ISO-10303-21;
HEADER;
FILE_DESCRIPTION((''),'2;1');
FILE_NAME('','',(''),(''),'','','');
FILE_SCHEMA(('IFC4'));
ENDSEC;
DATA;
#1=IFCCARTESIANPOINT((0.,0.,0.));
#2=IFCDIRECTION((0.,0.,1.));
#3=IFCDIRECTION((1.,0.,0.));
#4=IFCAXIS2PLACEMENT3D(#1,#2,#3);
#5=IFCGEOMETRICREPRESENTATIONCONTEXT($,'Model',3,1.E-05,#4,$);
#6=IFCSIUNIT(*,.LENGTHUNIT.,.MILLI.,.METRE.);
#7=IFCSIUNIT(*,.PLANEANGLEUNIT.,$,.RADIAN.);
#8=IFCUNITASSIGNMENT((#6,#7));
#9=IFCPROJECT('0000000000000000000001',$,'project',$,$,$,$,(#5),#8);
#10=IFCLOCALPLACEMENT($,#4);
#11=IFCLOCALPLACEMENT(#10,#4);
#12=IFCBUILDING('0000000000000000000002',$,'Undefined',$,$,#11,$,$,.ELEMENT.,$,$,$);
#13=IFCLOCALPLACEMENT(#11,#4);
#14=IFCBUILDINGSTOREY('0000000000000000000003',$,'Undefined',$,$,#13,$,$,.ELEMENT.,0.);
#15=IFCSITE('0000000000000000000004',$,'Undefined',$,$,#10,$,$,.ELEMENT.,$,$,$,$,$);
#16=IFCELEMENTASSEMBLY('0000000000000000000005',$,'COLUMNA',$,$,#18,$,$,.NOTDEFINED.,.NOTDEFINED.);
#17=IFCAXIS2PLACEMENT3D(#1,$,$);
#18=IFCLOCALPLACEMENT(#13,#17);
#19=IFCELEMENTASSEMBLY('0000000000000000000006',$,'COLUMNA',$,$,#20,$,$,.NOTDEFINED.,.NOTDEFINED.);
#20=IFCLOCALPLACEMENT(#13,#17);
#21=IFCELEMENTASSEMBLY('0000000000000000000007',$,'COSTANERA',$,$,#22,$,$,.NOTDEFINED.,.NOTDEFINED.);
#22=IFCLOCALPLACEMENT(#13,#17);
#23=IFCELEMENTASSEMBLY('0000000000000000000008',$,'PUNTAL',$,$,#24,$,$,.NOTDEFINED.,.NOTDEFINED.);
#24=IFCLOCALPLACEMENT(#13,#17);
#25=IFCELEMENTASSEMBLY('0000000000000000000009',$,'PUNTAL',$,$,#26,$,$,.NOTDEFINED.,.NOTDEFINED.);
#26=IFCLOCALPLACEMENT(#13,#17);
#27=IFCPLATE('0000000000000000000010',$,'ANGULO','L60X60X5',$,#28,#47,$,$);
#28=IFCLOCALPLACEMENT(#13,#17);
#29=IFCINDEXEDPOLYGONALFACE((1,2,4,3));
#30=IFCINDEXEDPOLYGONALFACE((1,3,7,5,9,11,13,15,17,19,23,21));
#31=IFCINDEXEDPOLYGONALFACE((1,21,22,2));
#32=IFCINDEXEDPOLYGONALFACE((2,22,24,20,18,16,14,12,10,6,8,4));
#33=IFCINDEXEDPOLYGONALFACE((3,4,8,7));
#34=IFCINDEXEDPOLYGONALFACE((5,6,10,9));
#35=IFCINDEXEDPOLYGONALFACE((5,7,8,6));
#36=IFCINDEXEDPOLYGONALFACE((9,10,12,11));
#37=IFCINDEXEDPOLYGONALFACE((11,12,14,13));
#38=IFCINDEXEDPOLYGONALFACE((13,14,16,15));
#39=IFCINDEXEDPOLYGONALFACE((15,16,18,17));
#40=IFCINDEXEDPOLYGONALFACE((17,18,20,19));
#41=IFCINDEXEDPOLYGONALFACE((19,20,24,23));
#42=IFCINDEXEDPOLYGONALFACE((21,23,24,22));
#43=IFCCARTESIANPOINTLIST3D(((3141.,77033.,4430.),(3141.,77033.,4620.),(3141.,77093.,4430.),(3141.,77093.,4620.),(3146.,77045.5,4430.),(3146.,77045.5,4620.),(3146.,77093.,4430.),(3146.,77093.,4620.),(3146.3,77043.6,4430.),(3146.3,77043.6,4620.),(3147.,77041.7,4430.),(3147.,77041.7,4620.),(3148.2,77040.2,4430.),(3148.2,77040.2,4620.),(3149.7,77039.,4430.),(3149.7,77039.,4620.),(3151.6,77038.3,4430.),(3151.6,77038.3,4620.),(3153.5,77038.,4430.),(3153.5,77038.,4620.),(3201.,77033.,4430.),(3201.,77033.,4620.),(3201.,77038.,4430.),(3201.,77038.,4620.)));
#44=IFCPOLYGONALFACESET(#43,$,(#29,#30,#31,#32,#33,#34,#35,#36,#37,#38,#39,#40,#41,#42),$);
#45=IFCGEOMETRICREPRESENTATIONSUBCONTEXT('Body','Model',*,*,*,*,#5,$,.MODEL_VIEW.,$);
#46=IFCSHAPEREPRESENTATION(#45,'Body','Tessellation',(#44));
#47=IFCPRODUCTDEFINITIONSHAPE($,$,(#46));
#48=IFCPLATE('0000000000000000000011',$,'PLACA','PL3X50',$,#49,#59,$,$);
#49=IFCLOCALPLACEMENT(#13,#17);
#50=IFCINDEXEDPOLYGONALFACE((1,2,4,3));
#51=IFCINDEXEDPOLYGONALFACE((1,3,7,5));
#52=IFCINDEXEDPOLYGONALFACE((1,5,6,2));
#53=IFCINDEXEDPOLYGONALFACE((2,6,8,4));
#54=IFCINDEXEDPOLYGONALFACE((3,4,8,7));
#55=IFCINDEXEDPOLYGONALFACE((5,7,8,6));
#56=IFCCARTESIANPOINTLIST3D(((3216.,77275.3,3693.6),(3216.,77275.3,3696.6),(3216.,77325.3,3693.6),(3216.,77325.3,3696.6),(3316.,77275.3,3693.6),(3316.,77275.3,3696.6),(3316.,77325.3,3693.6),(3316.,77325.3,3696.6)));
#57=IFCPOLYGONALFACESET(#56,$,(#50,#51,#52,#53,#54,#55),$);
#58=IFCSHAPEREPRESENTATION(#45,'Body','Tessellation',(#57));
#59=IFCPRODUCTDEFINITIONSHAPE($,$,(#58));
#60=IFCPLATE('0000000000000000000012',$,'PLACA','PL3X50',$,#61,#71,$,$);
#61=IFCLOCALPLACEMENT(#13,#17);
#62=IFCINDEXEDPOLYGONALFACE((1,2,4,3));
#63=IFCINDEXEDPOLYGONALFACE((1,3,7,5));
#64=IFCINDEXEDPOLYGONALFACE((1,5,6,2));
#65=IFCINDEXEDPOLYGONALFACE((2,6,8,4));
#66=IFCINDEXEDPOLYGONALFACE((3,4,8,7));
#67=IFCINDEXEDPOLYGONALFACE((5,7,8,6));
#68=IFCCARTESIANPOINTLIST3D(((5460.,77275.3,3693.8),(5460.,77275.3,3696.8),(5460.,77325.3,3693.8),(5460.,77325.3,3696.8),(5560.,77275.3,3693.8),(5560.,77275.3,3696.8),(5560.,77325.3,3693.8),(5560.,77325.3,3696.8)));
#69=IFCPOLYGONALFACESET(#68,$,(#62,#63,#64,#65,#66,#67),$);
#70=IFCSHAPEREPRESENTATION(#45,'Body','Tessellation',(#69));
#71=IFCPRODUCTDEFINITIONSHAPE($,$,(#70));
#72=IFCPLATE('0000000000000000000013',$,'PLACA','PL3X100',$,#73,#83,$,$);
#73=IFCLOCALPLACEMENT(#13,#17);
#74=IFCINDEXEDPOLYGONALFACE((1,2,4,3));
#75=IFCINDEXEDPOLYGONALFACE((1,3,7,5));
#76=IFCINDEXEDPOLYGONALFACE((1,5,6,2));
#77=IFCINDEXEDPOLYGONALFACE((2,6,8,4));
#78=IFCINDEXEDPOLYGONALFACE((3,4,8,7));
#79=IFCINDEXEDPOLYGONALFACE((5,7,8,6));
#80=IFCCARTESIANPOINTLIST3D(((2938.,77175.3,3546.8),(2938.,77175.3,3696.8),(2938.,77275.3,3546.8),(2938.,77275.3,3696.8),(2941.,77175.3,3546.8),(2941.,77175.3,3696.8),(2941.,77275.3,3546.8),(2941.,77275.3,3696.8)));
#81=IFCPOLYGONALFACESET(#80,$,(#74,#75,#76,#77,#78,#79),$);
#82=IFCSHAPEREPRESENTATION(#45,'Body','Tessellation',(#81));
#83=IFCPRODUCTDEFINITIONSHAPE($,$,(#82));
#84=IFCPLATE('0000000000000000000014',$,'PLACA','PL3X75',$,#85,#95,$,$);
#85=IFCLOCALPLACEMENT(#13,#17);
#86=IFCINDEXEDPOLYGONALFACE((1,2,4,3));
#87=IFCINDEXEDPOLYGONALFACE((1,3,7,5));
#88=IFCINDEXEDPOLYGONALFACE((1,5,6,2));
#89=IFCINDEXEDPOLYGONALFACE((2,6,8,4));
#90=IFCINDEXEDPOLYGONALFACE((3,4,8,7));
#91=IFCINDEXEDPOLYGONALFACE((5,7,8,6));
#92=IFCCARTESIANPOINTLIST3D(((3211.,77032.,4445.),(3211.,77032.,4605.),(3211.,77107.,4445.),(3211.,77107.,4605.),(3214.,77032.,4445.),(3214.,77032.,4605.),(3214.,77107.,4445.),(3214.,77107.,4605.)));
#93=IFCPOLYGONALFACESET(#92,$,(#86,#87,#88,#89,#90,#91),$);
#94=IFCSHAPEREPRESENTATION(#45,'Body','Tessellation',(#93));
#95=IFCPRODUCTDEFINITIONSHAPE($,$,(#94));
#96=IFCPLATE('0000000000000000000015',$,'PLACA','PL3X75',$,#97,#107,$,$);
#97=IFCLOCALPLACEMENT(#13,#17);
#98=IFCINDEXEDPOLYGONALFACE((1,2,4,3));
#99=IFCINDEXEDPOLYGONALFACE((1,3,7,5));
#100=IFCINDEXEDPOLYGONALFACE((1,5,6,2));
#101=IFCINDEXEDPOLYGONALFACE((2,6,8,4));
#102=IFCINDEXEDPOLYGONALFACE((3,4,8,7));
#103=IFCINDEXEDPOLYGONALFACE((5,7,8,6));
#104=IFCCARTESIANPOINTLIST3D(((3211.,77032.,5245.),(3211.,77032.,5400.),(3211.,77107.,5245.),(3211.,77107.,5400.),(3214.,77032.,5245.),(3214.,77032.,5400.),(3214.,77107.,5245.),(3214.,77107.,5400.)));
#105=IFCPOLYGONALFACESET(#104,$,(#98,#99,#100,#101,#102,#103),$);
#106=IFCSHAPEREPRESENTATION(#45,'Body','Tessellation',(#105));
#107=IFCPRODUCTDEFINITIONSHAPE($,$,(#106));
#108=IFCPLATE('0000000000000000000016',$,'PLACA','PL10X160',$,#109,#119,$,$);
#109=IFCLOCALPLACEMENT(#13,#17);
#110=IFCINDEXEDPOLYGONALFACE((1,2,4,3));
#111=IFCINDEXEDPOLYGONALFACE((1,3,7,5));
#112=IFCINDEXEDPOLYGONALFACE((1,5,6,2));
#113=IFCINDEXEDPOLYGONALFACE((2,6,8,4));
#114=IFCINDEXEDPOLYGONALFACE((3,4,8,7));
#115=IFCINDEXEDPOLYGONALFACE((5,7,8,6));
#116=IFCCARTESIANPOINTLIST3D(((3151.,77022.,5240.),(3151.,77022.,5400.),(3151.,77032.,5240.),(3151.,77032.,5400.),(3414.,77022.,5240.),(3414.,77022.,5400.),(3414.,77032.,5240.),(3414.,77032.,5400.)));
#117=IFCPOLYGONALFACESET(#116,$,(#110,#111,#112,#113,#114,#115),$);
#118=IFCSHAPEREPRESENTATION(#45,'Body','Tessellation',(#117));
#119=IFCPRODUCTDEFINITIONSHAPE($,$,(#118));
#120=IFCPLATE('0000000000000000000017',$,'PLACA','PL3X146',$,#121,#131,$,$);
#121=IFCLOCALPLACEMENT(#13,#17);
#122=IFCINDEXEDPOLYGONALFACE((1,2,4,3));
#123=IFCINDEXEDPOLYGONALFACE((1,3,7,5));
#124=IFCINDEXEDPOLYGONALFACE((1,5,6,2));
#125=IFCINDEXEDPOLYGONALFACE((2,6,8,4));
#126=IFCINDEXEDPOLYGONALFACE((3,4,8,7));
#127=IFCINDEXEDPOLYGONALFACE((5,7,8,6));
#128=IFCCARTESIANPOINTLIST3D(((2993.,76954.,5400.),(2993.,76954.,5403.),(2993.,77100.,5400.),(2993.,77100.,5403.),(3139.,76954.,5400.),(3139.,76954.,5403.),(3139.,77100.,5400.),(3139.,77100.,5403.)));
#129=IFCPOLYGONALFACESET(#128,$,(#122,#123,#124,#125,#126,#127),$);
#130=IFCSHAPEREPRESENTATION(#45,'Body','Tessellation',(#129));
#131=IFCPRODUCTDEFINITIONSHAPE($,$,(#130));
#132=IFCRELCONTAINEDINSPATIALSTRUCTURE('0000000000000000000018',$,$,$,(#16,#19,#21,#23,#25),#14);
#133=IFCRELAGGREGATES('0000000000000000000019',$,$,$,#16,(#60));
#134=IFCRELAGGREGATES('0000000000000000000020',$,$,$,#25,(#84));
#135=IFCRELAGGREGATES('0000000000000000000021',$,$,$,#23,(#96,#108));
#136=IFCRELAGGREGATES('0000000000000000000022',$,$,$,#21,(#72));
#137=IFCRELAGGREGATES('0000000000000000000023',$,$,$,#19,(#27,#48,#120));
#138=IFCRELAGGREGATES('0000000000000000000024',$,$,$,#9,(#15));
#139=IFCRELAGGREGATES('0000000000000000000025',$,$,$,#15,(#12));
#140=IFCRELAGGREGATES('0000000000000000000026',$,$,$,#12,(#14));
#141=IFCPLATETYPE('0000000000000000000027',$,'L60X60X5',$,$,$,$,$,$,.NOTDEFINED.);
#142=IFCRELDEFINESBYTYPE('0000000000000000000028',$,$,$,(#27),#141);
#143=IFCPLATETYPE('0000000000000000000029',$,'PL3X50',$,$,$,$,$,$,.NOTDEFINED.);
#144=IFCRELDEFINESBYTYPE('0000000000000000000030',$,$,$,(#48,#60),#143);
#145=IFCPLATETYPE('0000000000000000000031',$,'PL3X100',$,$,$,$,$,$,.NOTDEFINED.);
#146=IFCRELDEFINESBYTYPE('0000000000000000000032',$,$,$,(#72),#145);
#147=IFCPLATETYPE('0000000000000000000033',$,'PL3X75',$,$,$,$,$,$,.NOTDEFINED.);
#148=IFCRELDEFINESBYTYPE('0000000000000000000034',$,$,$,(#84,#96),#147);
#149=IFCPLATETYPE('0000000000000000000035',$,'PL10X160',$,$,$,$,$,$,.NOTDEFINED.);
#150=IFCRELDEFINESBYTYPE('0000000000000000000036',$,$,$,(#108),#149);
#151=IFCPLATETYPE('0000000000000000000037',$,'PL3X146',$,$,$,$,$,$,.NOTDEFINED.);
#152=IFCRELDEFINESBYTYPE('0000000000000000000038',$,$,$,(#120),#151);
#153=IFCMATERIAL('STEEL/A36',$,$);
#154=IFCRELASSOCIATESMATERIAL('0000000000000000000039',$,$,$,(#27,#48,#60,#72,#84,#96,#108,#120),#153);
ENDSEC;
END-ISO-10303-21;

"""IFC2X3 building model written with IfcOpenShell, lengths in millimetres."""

from ifc_helpers import new_model, si_unit, frame, origin_with_axes, origin_2d_with_axis, place, context, subcontext, project, spatial, polyline, l_section, outline, extrude, material, type_object, element, aggregate, save


model = new_model("IFC2X3")

# Units and contexts
model_context = context("Model", 3, precision=1e-05, world=origin_with_axes())
body_context = subcontext(model_context, "Body", "Model", "MODEL_VIEW")
ifc_project = project(units=[si_unit("LENGTHUNIT", "METRE", prefix="MILLI"), si_unit("PLANEANGLEUNIT", "RADIAN")], contexts=[model_context])

# Site, building, storey
site_placement = place(None, origin_with_axes())
site = spatial("IfcSite", under=ifc_project, at=site_placement, Name="Undefined", CompositionType="ELEMENT")
building_placement = place(site_placement, origin_with_axes())
building = spatial("IfcBuilding", under=site, at=building_placement, Name="Undefined", CompositionType="ELEMENT")
storey_placement = place(building_placement, origin_with_axes())
storey = spatial("IfcBuildingStorey", under=building, at=storey_placement, Name="Undefined", CompositionType="ELEMENT", Elevation=0.0)

# Element assemblies
assembly_1_placement = place(storey_placement, origin_with_axes())
assembly_1 = element("IfcElementAssembly", 1, at=assembly_1_placement, inside=storey, Name="COLUMNA", AssemblyPlace="NOTDEFINED", PredefinedType="NOTDEFINED")
ifc_material_1 = material(Name="STEEL/A36")
assembly_2_placement = place(storey_placement, origin_with_axes())
assembly_2 = element("IfcElementAssembly", 2, at=assembly_2_placement, inside=storey, Name="COLUMNA", AssemblyPlace="NOTDEFINED", PredefinedType="NOTDEFINED")
assembly_3_placement = place(storey_placement, origin_with_axes())
assembly_3 = element("IfcElementAssembly", 3, at=assembly_3_placement, inside=storey, Name="COSTANERA", AssemblyPlace="NOTDEFINED", PredefinedType="NOTDEFINED")
assembly_4_placement = place(storey_placement, origin_with_axes())
assembly_4 = element("IfcElementAssembly", 4, at=assembly_4_placement, inside=storey, Name="PUNTAL", AssemblyPlace="NOTDEFINED", PredefinedType="NOTDEFINED")
assembly_5_placement = place(storey_placement, origin_with_axes())
assembly_5 = element("IfcElementAssembly", 5, at=assembly_5_placement, inside=storey, Name="PUNTAL", AssemblyPlace="NOTDEFINED", PredefinedType="NOTDEFINED")

# Plates
plate_type_1 = type_object("IfcPlateType", Name="L60X60X5", PredefinedType="NOTDEFINED")
plate_1_placement = place(assembly_2_placement, frame((3171.0, 77063.0, 4620.0), z_axis=(0.0, 1.0, 0.0), x_axis=(0.0, 0.0, -1.0)))
plate_1 = element("IfcPlate", 6, at=plate_1_placement, type_object=plate_type_1, material=ifc_material_1, Name="ANGULO", Description="L60X60X5", context=body_context, shape_type="SweptSolid", body=[
    extrude(l_section(Depth=60.0, Width=60.0, Thickness=5.0, FilletRadius=7.5, at=origin_2d_with_axis()), frame((190.0, 0.0, 0.0), z_axis=(-1.0, 0.0, 0.0), x_axis=(0.0, -1.0, 0.0)), (0.0, 0.0, 1.0), 190.0),
])
plate_type_2 = type_object("IfcPlateType", Name="PL3X50", PredefinedType="NOTDEFINED")
plate_2_placement = place(assembly_2_placement, frame((3216.0, 77275.3, 3695.1), z_axis=(0.0, 0.0, -1.0), x_axis=(0.0, 1.0, 0.0)))
plate_2 = element("IfcPlate", 7, at=plate_2_placement, type_object=plate_type_2, material=ifc_material_1, Name="PLACA", Description="PL3X50", context=body_context, shape_type="SweptSolid", body=[
    extrude(outline(polyline([(0.0, 0.0), (50.0, 0.0), (50.0, 100.0), (0.0, 100.0), (0.0, 0.0)])), frame((0.0, 0.0, -1.5), z_axis=(0.0, 0.0, 1.0), x_axis=(1.0, 0.0, 0.0)), (0.0, 0.0, 1.0), 3.0),
])
plate_3_placement = place(assembly_1_placement, frame((5460.0, 77275.3, 3695.3), z_axis=(0.0, 0.0, -1.0), x_axis=(0.0, 1.0, 0.0)))
plate_3 = element("IfcPlate", 8, at=plate_3_placement, type_object=plate_type_2, material=ifc_material_1, Name="PLACA", Description="PL3X50", context=body_context, shape_type="SweptSolid", body=[
    extrude(outline(polyline([(0.0, 0.0), (50.0, 0.0), (50.0, 100.0), (0.0, 100.0), (0.0, 0.0)])), frame((0.0, 0.0, -1.5), z_axis=(0.0, 0.0, 1.0), x_axis=(1.0, 0.0, 0.0)), (0.0, 0.0, 1.0), 3.0),
])
aggregate(assembly_1, [plate_3])
plate_type_3 = type_object("IfcPlateType", Name="PL3X100", PredefinedType="NOTDEFINED")
plate_4_placement = place(assembly_3_placement, frame((2939.5, 77175.3, 3546.8), z_axis=(1.0, 0.0, 0.0), x_axis=(0.0, 1.0, 0.0)))
plate_4 = element("IfcPlate", 9, at=plate_4_placement, type_object=plate_type_3, material=ifc_material_1, Name="PLACA", Description="PL3X100", context=body_context, shape_type="SweptSolid", body=[
    extrude(outline(polyline([(0.0, 0.0), (100.0, 0.0), (100.0, 150.0), (0.0, 150.0), (0.0, 0.0)])), frame((0.0, 0.0, -1.5), z_axis=(0.0, 0.0, 1.0), x_axis=(1.0, 0.0, 0.0)), (0.0, 0.0, 1.0), 3.0),
])
plate_type_4 = type_object("IfcPlateType", Name="PL3X75", PredefinedType="NOTDEFINED")
plate_5_placement = place(assembly_5_placement, frame((3212.5, 77107.0, 4605.0), z_axis=(1.0, 0.0, 0.0), x_axis=(0.0, -1.0, 0.0)))
plate_5 = element("IfcPlate", 10, at=plate_5_placement, type_object=plate_type_4, material=ifc_material_1, Name="PLACA", Description="PL3X75", context=body_context, shape_type="SweptSolid", body=[
    extrude(outline(polyline([(0.0, 0.0), (75.0, 0.0), (75.0, 160.0), (0.0, 160.0), (0.0, 0.0)])), frame((0.0, 0.0, -1.5), z_axis=(0.0, 0.0, 1.0), x_axis=(1.0, 0.0, 0.0)), (0.0, 0.0, 1.0), 3.0),
])
aggregate(assembly_5, [plate_5])
plate_6_placement = place(assembly_4_placement, frame((3212.5, 77032.0, 5245.0), z_axis=(1.0, 0.0, 0.0), x_axis=(0.0, 1.0, 0.0)))
plate_6 = element("IfcPlate", 11, at=plate_6_placement, type_object=plate_type_4, material=ifc_material_1, Name="PLACA", Description="PL3X75", context=body_context, shape_type="SweptSolid", body=[
    extrude(outline(polyline([(0.0, 0.0), (75.0, 0.0), (75.0, 155.0), (0.0, 155.0), (0.0, 0.0)])), frame((0.0, 0.0, -1.5), z_axis=(0.0, 0.0, 1.0), x_axis=(1.0, 0.0, 0.0)), (0.0, 0.0, 1.0), 3.0),
])
plate_type_5 = type_object("IfcPlateType", Name="PL10X160", PredefinedType="NOTDEFINED")
plate_7_placement = place(assembly_4_placement, frame((3151.0, 77027.0, 5320.0), z_axis=(0.0, 1.0, 0.0), x_axis=(1.0, 0.0, 0.0)))
plate_7 = element("IfcPlate", 12, at=plate_7_placement, type_object=plate_type_5, material=ifc_material_1, Name="PLACA", Description="PL10X160", context=body_context, shape_type="SweptSolid", body=[
    extrude(outline(polyline([(0.0, -80.0), (0.0, 80.0), (263.0, 80.0), (263.0, -80.0), (0.0, -80.0)])), frame((0.0, 0.0, -5.0), z_axis=(0.0, 0.0, 1.0), x_axis=(1.0, 0.0, 0.0)), (0.0, 0.0, 1.0), 10.0),
])
aggregate(assembly_4, [plate_6, plate_7])
plate_type_6 = type_object("IfcPlateType", Name="PL3X146", PredefinedType="NOTDEFINED")
plate_8_placement = place(assembly_2_placement, frame((3139.0, 77100.0, 5401.5), z_axis=(0.0, 0.0, -1.0), x_axis=(0.0, -1.0, 0.0)))
plate_8 = element("IfcPlate", 13, at=plate_8_placement, type_object=plate_type_6, material=ifc_material_1, Name="PLACA", Description="PL3X146", context=body_context, shape_type="SweptSolid", body=[
    extrude(outline(polyline([(0.0, 0.0), (146.0, 0.0), (146.0, 146.0), (0.0, 146.0), (0.0, 0.0)])), frame((0.0, 0.0, -1.5), z_axis=(0.0, 0.0, 1.0), x_axis=(1.0, 0.0, 0.0)), (0.0, 0.0, 1.0), 3.0),
])

aggregate(assembly_3, [plate_4])
aggregate(assembly_2, [plate_1, plate_2, plate_8])

save(model, "model.ifc")
